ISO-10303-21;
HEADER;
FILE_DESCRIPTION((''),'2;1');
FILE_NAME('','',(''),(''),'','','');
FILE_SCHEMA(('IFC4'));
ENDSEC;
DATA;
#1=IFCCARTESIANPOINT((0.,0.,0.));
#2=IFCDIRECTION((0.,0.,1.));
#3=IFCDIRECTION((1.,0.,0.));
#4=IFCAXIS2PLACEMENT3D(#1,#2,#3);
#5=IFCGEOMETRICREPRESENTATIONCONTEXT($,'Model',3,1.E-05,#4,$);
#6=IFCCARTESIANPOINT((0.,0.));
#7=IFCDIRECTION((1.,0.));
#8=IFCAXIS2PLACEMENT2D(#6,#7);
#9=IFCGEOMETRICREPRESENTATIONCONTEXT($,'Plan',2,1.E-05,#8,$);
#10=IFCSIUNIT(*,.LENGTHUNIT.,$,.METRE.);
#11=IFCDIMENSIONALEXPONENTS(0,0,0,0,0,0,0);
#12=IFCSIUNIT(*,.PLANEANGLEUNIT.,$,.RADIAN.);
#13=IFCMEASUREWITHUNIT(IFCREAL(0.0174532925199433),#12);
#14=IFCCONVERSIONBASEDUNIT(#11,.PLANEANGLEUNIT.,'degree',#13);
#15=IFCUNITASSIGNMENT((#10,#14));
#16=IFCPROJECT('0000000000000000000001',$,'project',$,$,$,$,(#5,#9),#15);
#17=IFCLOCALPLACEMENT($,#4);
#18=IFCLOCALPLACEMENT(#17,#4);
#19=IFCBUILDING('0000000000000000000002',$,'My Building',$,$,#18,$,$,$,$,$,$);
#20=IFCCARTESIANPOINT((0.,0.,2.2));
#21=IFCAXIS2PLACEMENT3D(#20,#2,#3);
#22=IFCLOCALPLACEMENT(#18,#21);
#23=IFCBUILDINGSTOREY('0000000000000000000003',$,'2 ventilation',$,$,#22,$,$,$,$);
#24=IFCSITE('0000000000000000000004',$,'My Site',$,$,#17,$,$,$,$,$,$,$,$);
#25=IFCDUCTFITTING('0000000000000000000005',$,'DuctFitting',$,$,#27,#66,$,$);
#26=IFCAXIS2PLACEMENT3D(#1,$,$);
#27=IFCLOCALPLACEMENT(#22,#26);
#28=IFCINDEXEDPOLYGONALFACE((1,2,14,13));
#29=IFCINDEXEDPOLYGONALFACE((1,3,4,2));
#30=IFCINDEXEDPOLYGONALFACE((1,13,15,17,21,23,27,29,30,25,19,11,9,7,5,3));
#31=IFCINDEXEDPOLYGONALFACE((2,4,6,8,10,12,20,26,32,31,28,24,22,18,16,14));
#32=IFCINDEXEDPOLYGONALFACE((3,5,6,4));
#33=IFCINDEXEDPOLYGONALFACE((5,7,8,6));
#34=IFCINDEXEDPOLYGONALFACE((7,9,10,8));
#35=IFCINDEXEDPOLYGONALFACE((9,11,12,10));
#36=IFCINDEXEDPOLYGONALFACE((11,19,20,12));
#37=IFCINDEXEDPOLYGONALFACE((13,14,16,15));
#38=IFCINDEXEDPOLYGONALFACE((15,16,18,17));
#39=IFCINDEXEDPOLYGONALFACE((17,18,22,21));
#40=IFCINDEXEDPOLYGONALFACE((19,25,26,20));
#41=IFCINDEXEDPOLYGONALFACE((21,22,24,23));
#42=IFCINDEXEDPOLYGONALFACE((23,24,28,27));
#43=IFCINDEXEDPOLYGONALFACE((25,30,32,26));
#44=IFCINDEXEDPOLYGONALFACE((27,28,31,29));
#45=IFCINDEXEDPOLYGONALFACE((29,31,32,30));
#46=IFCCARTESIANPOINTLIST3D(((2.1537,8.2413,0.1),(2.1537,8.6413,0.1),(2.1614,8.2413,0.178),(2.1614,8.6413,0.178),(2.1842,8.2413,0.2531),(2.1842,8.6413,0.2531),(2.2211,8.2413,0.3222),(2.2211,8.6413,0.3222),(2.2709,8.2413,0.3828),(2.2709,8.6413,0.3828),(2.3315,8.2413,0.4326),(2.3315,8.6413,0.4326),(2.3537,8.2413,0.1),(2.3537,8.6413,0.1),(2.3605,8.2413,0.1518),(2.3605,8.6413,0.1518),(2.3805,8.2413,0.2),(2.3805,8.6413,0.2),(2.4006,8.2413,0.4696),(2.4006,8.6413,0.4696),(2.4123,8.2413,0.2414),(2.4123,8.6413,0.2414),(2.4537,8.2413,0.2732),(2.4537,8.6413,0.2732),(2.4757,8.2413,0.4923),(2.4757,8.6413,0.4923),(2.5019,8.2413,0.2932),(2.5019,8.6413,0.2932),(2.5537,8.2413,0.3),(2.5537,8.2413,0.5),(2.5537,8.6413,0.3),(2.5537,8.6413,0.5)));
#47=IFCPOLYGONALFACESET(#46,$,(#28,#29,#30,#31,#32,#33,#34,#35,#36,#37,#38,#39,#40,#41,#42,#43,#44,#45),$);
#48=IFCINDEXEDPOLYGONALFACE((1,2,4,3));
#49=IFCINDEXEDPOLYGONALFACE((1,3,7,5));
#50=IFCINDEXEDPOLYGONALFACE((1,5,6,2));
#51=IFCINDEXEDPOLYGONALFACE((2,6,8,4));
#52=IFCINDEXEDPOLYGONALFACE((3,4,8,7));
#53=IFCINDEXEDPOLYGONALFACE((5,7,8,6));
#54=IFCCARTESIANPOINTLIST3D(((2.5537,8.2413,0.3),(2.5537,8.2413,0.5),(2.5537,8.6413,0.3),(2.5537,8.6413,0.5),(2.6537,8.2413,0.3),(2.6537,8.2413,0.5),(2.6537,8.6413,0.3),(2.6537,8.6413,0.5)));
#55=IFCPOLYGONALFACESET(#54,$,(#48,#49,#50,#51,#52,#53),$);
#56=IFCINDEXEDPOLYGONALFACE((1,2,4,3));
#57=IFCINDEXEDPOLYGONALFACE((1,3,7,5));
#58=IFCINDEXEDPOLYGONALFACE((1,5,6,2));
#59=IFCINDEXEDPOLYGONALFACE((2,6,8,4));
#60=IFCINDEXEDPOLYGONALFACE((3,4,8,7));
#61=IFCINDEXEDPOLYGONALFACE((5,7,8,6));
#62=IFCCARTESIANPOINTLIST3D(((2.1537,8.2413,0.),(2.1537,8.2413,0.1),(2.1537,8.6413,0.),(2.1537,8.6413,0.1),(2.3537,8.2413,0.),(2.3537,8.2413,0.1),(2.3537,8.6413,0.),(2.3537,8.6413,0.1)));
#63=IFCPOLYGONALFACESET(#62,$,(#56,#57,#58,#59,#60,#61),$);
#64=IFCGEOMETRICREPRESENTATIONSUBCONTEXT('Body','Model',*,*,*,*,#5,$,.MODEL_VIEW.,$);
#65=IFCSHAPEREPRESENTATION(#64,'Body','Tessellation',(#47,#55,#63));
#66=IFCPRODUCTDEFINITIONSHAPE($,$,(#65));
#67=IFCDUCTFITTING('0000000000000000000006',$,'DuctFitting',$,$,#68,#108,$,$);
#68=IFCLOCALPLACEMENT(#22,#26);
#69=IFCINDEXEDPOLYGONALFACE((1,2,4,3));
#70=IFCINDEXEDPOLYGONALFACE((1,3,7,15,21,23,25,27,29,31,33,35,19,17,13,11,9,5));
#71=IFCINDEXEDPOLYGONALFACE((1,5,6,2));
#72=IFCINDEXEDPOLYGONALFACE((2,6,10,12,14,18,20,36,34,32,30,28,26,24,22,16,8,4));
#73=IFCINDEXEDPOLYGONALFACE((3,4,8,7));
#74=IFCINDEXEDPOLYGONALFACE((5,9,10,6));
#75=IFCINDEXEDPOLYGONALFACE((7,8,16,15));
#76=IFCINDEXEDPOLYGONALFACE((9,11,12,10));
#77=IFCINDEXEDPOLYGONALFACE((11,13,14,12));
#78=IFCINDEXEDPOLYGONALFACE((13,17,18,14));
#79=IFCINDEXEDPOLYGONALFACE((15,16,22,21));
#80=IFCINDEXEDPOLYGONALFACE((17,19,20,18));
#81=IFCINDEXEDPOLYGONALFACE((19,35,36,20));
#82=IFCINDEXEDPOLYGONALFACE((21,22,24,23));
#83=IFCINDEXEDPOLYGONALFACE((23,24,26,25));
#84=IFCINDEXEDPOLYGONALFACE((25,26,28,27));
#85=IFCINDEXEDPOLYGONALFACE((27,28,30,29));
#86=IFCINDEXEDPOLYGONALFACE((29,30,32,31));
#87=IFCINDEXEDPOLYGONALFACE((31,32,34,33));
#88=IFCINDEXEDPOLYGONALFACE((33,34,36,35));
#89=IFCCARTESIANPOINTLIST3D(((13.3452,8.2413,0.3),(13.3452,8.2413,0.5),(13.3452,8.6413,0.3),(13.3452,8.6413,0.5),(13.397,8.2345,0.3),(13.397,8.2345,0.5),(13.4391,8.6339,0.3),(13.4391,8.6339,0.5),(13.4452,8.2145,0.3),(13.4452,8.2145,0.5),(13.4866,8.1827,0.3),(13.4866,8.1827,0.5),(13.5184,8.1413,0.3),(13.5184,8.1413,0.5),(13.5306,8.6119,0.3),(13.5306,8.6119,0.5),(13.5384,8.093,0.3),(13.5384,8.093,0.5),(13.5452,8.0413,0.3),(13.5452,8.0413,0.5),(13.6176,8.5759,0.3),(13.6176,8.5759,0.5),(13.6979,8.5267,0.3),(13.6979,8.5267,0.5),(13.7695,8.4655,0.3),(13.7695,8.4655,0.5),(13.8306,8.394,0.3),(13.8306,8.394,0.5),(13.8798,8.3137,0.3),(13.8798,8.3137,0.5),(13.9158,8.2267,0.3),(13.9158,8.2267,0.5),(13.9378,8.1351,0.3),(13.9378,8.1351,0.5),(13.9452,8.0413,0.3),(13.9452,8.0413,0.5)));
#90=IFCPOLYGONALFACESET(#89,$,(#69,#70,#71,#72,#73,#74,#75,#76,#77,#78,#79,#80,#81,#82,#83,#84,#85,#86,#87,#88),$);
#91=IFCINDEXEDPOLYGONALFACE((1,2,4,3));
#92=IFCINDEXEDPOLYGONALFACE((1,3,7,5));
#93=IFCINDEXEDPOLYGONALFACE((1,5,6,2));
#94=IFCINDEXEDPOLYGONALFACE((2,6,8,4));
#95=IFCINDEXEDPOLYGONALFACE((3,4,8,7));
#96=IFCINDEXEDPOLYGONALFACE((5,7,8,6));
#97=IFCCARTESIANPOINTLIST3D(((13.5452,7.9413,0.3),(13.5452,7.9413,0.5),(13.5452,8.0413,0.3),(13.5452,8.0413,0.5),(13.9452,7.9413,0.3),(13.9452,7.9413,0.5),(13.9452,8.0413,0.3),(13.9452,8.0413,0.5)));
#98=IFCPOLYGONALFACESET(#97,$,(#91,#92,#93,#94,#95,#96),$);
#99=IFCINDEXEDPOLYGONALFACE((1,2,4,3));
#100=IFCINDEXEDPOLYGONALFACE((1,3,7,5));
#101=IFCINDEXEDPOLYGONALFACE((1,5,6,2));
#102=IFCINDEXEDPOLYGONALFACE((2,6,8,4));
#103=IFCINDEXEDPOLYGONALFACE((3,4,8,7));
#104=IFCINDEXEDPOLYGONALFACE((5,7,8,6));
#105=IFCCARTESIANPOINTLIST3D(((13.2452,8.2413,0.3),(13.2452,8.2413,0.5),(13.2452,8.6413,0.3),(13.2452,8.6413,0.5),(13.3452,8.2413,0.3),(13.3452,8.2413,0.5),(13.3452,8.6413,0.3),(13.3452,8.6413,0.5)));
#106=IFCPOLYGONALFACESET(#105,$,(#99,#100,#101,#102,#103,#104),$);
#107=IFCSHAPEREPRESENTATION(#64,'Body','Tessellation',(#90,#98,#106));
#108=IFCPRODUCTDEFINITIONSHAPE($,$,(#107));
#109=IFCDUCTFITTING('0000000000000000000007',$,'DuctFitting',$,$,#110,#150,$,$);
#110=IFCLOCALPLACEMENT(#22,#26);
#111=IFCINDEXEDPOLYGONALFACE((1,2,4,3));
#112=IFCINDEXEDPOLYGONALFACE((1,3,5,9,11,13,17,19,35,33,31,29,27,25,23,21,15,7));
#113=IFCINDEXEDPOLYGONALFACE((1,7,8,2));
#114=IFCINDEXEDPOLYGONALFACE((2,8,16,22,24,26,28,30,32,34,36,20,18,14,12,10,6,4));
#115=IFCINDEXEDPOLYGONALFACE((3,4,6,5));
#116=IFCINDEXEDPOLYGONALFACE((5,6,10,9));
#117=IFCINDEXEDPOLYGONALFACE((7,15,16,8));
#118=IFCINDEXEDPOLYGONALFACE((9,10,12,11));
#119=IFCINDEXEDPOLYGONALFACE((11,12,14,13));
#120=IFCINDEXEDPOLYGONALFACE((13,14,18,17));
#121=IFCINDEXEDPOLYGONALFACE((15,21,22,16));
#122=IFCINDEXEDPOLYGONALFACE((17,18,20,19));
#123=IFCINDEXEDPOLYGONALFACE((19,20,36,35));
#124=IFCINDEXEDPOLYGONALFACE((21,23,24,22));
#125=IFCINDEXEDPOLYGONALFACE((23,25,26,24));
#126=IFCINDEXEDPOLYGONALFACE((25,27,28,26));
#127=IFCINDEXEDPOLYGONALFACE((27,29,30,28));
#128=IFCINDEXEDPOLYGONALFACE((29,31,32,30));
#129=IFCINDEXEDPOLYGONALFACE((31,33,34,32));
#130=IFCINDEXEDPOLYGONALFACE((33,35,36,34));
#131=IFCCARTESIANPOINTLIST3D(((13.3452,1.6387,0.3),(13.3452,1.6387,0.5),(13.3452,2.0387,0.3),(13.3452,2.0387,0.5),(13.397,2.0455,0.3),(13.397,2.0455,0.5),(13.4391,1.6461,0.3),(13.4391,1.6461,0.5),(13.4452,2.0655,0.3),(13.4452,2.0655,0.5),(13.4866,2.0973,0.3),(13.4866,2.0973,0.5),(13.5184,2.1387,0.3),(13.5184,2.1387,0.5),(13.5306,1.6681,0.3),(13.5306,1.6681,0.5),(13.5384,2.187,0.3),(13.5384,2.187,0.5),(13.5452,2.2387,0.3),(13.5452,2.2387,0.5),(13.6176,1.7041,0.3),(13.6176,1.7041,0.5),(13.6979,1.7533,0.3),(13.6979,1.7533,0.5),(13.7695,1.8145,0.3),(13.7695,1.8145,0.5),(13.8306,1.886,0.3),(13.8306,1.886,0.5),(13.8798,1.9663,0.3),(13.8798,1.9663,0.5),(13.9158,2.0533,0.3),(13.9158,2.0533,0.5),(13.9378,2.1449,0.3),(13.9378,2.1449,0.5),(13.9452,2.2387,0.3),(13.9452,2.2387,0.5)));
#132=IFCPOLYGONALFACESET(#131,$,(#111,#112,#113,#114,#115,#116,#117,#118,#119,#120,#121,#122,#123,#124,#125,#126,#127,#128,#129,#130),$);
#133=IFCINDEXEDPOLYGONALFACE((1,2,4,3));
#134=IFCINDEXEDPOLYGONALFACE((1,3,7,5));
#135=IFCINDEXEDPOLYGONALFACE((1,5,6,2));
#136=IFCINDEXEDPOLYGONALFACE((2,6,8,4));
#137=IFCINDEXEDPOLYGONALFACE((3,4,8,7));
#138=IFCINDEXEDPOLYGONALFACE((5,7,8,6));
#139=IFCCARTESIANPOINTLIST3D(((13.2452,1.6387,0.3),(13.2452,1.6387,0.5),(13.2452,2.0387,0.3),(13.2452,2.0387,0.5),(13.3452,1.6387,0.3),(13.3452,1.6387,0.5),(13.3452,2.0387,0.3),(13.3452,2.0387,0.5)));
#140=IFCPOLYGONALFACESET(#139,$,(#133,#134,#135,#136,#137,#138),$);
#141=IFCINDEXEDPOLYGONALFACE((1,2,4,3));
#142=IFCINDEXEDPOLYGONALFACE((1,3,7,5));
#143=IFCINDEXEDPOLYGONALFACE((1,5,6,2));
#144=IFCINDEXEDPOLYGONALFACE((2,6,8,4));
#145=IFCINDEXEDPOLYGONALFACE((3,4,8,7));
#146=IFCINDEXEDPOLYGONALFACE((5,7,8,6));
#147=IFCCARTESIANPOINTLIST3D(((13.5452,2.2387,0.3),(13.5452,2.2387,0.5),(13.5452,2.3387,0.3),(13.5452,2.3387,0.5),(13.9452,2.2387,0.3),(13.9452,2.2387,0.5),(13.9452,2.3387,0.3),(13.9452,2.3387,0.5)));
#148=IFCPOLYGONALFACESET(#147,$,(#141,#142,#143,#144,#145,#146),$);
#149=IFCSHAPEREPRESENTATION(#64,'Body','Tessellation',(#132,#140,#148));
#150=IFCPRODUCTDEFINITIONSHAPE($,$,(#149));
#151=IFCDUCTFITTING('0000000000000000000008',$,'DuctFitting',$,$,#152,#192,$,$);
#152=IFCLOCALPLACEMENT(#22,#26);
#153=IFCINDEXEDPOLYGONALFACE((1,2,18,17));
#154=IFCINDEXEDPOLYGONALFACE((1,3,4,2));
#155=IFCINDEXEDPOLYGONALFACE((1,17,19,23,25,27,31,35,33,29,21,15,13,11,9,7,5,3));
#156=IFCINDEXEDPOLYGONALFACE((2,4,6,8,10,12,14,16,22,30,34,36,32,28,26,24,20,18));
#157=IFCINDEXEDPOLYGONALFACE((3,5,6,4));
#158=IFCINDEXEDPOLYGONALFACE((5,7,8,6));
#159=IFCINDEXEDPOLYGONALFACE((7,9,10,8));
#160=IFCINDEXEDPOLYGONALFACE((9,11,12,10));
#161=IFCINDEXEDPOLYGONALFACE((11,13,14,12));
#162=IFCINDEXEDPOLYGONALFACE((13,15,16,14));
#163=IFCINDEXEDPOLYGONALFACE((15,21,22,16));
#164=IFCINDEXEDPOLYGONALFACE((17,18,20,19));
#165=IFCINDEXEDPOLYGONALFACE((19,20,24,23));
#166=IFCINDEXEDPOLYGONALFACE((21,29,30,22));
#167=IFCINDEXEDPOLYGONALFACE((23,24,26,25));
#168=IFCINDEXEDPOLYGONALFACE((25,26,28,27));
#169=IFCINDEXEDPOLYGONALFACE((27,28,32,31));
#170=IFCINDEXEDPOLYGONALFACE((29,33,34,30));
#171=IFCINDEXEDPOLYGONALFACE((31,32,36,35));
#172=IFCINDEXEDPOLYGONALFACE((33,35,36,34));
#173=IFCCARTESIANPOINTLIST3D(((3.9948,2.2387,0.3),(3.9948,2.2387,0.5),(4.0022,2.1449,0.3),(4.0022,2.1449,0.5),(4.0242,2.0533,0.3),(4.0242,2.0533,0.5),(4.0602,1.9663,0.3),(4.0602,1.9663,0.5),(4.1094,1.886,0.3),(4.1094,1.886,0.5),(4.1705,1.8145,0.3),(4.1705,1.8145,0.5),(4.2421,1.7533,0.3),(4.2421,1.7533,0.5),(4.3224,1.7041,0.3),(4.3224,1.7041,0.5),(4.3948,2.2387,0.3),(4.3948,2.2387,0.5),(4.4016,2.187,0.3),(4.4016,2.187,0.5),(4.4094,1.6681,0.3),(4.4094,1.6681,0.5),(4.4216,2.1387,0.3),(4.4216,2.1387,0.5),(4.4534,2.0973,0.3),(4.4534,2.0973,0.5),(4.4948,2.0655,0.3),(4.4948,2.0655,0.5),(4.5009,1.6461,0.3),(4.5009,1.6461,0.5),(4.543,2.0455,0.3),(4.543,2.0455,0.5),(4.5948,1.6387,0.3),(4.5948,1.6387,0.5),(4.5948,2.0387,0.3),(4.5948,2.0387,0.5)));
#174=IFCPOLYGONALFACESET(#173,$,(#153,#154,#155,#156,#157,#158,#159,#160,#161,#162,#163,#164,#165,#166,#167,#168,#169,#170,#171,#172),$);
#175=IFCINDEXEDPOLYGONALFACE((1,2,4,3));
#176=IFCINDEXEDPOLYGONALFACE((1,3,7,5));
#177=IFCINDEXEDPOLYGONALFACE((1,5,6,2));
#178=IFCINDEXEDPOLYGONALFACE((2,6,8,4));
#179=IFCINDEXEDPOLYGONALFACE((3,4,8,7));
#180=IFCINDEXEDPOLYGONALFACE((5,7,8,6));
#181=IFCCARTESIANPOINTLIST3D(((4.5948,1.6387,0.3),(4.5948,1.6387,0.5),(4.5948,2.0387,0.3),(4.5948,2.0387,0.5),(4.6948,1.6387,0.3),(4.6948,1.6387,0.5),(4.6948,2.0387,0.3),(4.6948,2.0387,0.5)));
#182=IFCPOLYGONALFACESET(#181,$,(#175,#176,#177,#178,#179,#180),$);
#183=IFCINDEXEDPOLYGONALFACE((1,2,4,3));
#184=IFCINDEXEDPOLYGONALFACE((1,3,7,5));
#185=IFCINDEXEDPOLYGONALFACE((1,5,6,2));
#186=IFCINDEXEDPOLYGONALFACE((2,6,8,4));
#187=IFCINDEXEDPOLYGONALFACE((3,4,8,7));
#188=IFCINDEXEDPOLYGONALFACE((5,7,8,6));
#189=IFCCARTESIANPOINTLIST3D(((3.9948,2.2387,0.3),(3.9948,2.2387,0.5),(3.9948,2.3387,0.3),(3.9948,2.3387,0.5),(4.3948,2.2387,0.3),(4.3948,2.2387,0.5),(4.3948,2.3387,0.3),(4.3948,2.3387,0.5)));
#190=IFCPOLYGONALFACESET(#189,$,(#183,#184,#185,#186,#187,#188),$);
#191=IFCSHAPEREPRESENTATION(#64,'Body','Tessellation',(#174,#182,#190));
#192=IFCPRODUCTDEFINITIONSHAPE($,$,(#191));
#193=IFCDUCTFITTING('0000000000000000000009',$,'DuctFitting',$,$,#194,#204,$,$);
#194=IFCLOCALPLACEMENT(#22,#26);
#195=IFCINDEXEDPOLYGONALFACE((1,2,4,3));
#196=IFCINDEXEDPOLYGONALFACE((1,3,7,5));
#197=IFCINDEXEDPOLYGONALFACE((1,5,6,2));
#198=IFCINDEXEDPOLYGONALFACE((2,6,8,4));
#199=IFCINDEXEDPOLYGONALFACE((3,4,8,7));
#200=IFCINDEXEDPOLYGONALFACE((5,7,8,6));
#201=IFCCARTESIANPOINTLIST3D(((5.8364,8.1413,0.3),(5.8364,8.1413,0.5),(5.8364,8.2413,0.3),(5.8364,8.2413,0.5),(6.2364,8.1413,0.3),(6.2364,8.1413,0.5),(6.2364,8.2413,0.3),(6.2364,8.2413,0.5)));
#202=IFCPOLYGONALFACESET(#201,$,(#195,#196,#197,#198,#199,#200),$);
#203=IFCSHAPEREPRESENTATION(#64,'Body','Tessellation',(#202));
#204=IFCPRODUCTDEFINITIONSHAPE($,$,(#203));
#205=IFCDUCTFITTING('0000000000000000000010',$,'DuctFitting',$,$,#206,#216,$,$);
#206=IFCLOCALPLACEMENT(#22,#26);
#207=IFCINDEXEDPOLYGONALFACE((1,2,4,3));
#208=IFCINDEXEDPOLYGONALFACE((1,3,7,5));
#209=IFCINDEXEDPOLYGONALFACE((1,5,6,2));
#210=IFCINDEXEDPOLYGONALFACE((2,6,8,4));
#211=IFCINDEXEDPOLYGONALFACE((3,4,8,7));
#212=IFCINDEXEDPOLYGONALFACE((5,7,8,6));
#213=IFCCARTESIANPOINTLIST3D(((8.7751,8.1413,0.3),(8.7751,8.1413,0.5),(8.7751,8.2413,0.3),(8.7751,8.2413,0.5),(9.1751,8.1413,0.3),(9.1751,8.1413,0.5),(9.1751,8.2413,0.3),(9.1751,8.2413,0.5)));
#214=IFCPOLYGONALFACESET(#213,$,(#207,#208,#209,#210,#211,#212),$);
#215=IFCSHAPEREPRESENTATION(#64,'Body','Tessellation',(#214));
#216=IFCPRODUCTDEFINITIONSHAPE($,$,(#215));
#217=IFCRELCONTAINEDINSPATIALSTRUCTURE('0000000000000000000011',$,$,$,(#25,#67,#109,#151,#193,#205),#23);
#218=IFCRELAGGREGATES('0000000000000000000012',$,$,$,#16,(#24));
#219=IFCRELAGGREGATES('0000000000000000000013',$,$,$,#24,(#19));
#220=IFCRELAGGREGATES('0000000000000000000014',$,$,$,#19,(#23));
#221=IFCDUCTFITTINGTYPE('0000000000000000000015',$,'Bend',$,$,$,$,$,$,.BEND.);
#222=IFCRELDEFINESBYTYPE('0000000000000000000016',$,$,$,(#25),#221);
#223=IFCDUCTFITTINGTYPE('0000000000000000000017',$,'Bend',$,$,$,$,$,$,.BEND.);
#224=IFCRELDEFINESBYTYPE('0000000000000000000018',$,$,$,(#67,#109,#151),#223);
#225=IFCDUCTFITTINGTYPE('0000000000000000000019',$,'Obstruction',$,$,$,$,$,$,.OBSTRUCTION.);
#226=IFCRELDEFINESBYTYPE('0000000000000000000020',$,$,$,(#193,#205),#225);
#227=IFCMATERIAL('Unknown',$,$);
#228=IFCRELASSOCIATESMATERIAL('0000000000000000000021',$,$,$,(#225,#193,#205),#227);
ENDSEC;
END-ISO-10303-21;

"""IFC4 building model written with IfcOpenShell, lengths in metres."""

from ifc_helpers import new_model, entity, si_unit, converted_unit, frame, origin_with_axes, origin_2d_with_axis, place, context, subcontext, project, spatial, line, arc, indexed_curve, outline, extrude, source, transform, mapped, material, material_profile, profile_set, profile_usage, type_object, type_shapes, element, save


model = new_model("IFC4")

# Units and contexts
model_context = context("Model", 3, precision=1e-05, world=origin_with_axes())
plan_context = context("Plan", 2, precision=1e-05, world=origin_2d_with_axis())
body_context = subcontext(model_context, "Body", "Model", "MODEL_VIEW")
ifc_project = project(units=[si_unit("LENGTHUNIT", "METRE"), converted_unit("PLANEANGLEUNIT", "degree", entity("IfcReal", 0.0174532925199433), si_unit("PLANEANGLEUNIT", "RADIAN"), dimensions=[0, 0, 0, 0, 0, 0, 0])], contexts=[model_context, plan_context])

# Site, building, storey
site_placement = place(None, origin_with_axes())
site = spatial("IfcSite", under=ifc_project, at=site_placement, Name="My Site")
building_placement = place(site_placement, origin_with_axes())
building = spatial("IfcBuilding", under=site, at=building_placement, Name="My Building")
storey_placement = place(building_placement, frame((0.0, 0.0, 2.2), z_axis=(0.0, 0.0, 1.0), x_axis=(1.0, 0.0, 0.0)))
storey = spatial("IfcBuildingStorey", under=building, at=storey_placement, Name="2 ventilation")

# Shared definitions
ifc_material = material(Name="Unknown")

# Duct fittings
duct_fitting_type_1 = type_object("IfcDuctFittingType", Name="Bend", PredefinedType="BEND")
shared_shape_1 = source(origin_with_axes(), body_context, "Body", "SweptSolid", [
    extrude(outline(indexed_curve([(-0.1, 0.0), (-0.1586, -0.1414), (-0.3, -0.2), (-0.3, -0.4), (-0.0172, -0.2828), (0.1, 0.0)], segments=[arc(1, 2, 3), line(3, 4), arc(4, 5, 6), line(6, 1)])), frame((-0.2, 0.0, -0.1), z_axis=(1.0, 0.0, 0.0), x_axis=(0.0, 1.0, 0.0)), (0.0, 0.0, 1.0), 0.4),
    extrude(outline(indexed_curve([(-0.2, 0.1), (0.2, 0.1), (0.2, -0.1), (-0.2, -0.1), (-0.2, 0.1)])), origin_with_axes(), (0.0, 0.0, -1.0), 0.1),
    extrude(outline(indexed_curve([(-0.2, 0.1), (0.2, 0.1), (0.2, -0.1), (-0.2, -0.1), (-0.2, 0.1)])), frame((0.0, -0.3, -0.4), z_axis=(0.0, -1.0, -0.000001), x_axis=(1.0, 0.0, 0.0)), (0.0, 0.0, 1.0), 0.1),
])
type_shapes(duct_fitting_type_1, [shared_shape_1])
duct_fitting_1_placement = place(storey_placement, frame((2.6537, 8.4413, 0.4), z_axis=(1.0, 0.0, 0.0), x_axis=(0.0, 1.0, 0.0)))
element("IfcDuctFitting", 1, at=duct_fitting_1_placement, inside=storey, type_object=duct_fitting_type_1, Name="DuctFitting", context=body_context, shape_type="MappedRepresentation", body=[
    mapped(shared_shape_1, transform((0.0, 0.0, 0.0), x_axis=(1.0, 0.0, 0.0), y_axis=(0.0, 1.0, 0.0), z_axis=(0.0, 0.0, 1.0), scale=1.0)),
])
duct_fitting_type_2 = type_object("IfcDuctFittingType", Name="Bend", PredefinedType="BEND")
shared_shape_2 = source(origin_with_axes(), body_context, "Body", "SweptSolid", [
    extrude(outline(indexed_curve([(0.2, 0.0), (0.2586, 0.1414), (0.4, 0.2), (0.4, 0.6), (-0.0243, 0.4243), (-0.2, 0.0)], segments=[arc(1, 2, 3), line(3, 4), arc(4, 5, 6), line(6, 1)])), frame((0.0, -0.1, 0.1), z_axis=(0.0, -1.0, 0.0), x_axis=(1.0, 0.0, 0.0)), (0.0, 0.0, -1.0), 0.2),
    extrude(outline(indexed_curve([(-0.2, 0.1), (0.2, 0.1), (0.2, -0.1), (-0.2, -0.1), (-0.2, 0.1)])), origin_with_axes(), (0.0, 0.0, 1.0), 0.1),
    extrude(outline(indexed_curve([(-0.2, 0.1), (0.2, 0.1), (0.2, -0.1), (-0.2, -0.1), (-0.2, 0.1)])), frame((0.4, 0.0, 0.5), z_axis=(1.0, 0.0, 0.0), x_axis=(0.0, 0.0, 1.0)), (0.0, 0.0, 1.0), 0.1),
])
type_shapes(duct_fitting_type_2, [shared_shape_2])
for number, where, z_axis, x_axis, name in (
    (2, (13.7452, 7.9413, 0.4), (0.0, 1.0, 0.000001), (-1.0, 0.0, 0.0), "DuctFitting"),
    (3, (13.2452, 1.8387, 0.4), (1.0, 0.0, 0.0), (0.0, 1.0, 0.0), "DuctFitting"),
    (4, (4.6948, 1.8387, 0.4), (-1.0, 0.0, -0.000001), (0.0, 1.0, 0.0), "DuctFitting"),
):
    element("IfcDuctFitting", number, at=place(storey_placement, frame(where, z_axis=z_axis, x_axis=x_axis)), inside=storey, type_object=duct_fitting_type_2, Name=name, context=body_context, shape_type="MappedRepresentation", body=[
        mapped(shared_shape_2, transform((0.0, 0.0, 0.0), x_axis=(1.0, 0.0, 0.0), y_axis=(0.0, 1.0, 0.0), z_axis=(0.0, 0.0, 1.0), scale=1.0)),
    ])
ifc_material_profile_1 = material_profile(ifc_material, outline(indexed_curve([(-0.2, 0.1), (0.2, 0.1), (0.2, -0.1), (-0.2, -0.1), (-0.2, 0.1)])))
ifc_profile_set_1 = profile_set([ifc_material_profile_1])
ifc_profile_usage_1 = profile_usage(ifc_profile_set_1, cardinal=2)
duct_fitting_type_3 = type_object("IfcDuctFittingType", Name="Obstruction", PredefinedType="OBSTRUCTION", material=ifc_profile_set_1)
duct_fitting_2_placement = place(storey_placement, frame((6.0364, 8.1413, 0.3), z_axis=(0.0, 1.0, 0.000007), x_axis=(-1.0, 0.0, 0.0)))
element("IfcDuctFitting", 5, at=duct_fitting_2_placement, inside=storey, type_object=duct_fitting_type_3, material=ifc_profile_usage_1, Name="DuctFitting", context=body_context, shape_type="SweptSolid", body=[
    extrude(outline(indexed_curve([(-0.2, 0.1), (0.2, 0.1), (0.2, -0.1), (-0.2, -0.1), (-0.2, 0.1)])), frame((0.0, 0.1, 0.0), z_axis=(0.0, 0.0, 1.0), x_axis=(1.0, 0.0, 0.0)), (0.0, 0.0, 1.0), 0.1),
])
ifc_profile_usage_2 = profile_usage(ifc_profile_set_1, cardinal=2)
duct_fitting_3_placement = place(storey_placement, frame((8.9751, 8.1413, 0.3), z_axis=(0.0, 1.0, 0.000007), x_axis=(-1.0, 0.0, 0.0)))
element("IfcDuctFitting", 6, at=duct_fitting_3_placement, inside=storey, type_object=duct_fitting_type_3, material=ifc_profile_usage_2, Name="DuctFitting", context=body_context, shape_type="SweptSolid", body=[
    extrude(outline(indexed_curve([(-0.2, 0.1), (0.2, 0.1), (0.2, -0.1), (-0.2, -0.1), (-0.2, 0.1)])), frame((0.0, 0.1, 0.0), z_axis=(0.0, 0.0, 1.0), x_axis=(1.0, 0.0, 0.0)), (0.0, 0.0, 1.0), 0.1),
])

save(model, "model.ifc")
